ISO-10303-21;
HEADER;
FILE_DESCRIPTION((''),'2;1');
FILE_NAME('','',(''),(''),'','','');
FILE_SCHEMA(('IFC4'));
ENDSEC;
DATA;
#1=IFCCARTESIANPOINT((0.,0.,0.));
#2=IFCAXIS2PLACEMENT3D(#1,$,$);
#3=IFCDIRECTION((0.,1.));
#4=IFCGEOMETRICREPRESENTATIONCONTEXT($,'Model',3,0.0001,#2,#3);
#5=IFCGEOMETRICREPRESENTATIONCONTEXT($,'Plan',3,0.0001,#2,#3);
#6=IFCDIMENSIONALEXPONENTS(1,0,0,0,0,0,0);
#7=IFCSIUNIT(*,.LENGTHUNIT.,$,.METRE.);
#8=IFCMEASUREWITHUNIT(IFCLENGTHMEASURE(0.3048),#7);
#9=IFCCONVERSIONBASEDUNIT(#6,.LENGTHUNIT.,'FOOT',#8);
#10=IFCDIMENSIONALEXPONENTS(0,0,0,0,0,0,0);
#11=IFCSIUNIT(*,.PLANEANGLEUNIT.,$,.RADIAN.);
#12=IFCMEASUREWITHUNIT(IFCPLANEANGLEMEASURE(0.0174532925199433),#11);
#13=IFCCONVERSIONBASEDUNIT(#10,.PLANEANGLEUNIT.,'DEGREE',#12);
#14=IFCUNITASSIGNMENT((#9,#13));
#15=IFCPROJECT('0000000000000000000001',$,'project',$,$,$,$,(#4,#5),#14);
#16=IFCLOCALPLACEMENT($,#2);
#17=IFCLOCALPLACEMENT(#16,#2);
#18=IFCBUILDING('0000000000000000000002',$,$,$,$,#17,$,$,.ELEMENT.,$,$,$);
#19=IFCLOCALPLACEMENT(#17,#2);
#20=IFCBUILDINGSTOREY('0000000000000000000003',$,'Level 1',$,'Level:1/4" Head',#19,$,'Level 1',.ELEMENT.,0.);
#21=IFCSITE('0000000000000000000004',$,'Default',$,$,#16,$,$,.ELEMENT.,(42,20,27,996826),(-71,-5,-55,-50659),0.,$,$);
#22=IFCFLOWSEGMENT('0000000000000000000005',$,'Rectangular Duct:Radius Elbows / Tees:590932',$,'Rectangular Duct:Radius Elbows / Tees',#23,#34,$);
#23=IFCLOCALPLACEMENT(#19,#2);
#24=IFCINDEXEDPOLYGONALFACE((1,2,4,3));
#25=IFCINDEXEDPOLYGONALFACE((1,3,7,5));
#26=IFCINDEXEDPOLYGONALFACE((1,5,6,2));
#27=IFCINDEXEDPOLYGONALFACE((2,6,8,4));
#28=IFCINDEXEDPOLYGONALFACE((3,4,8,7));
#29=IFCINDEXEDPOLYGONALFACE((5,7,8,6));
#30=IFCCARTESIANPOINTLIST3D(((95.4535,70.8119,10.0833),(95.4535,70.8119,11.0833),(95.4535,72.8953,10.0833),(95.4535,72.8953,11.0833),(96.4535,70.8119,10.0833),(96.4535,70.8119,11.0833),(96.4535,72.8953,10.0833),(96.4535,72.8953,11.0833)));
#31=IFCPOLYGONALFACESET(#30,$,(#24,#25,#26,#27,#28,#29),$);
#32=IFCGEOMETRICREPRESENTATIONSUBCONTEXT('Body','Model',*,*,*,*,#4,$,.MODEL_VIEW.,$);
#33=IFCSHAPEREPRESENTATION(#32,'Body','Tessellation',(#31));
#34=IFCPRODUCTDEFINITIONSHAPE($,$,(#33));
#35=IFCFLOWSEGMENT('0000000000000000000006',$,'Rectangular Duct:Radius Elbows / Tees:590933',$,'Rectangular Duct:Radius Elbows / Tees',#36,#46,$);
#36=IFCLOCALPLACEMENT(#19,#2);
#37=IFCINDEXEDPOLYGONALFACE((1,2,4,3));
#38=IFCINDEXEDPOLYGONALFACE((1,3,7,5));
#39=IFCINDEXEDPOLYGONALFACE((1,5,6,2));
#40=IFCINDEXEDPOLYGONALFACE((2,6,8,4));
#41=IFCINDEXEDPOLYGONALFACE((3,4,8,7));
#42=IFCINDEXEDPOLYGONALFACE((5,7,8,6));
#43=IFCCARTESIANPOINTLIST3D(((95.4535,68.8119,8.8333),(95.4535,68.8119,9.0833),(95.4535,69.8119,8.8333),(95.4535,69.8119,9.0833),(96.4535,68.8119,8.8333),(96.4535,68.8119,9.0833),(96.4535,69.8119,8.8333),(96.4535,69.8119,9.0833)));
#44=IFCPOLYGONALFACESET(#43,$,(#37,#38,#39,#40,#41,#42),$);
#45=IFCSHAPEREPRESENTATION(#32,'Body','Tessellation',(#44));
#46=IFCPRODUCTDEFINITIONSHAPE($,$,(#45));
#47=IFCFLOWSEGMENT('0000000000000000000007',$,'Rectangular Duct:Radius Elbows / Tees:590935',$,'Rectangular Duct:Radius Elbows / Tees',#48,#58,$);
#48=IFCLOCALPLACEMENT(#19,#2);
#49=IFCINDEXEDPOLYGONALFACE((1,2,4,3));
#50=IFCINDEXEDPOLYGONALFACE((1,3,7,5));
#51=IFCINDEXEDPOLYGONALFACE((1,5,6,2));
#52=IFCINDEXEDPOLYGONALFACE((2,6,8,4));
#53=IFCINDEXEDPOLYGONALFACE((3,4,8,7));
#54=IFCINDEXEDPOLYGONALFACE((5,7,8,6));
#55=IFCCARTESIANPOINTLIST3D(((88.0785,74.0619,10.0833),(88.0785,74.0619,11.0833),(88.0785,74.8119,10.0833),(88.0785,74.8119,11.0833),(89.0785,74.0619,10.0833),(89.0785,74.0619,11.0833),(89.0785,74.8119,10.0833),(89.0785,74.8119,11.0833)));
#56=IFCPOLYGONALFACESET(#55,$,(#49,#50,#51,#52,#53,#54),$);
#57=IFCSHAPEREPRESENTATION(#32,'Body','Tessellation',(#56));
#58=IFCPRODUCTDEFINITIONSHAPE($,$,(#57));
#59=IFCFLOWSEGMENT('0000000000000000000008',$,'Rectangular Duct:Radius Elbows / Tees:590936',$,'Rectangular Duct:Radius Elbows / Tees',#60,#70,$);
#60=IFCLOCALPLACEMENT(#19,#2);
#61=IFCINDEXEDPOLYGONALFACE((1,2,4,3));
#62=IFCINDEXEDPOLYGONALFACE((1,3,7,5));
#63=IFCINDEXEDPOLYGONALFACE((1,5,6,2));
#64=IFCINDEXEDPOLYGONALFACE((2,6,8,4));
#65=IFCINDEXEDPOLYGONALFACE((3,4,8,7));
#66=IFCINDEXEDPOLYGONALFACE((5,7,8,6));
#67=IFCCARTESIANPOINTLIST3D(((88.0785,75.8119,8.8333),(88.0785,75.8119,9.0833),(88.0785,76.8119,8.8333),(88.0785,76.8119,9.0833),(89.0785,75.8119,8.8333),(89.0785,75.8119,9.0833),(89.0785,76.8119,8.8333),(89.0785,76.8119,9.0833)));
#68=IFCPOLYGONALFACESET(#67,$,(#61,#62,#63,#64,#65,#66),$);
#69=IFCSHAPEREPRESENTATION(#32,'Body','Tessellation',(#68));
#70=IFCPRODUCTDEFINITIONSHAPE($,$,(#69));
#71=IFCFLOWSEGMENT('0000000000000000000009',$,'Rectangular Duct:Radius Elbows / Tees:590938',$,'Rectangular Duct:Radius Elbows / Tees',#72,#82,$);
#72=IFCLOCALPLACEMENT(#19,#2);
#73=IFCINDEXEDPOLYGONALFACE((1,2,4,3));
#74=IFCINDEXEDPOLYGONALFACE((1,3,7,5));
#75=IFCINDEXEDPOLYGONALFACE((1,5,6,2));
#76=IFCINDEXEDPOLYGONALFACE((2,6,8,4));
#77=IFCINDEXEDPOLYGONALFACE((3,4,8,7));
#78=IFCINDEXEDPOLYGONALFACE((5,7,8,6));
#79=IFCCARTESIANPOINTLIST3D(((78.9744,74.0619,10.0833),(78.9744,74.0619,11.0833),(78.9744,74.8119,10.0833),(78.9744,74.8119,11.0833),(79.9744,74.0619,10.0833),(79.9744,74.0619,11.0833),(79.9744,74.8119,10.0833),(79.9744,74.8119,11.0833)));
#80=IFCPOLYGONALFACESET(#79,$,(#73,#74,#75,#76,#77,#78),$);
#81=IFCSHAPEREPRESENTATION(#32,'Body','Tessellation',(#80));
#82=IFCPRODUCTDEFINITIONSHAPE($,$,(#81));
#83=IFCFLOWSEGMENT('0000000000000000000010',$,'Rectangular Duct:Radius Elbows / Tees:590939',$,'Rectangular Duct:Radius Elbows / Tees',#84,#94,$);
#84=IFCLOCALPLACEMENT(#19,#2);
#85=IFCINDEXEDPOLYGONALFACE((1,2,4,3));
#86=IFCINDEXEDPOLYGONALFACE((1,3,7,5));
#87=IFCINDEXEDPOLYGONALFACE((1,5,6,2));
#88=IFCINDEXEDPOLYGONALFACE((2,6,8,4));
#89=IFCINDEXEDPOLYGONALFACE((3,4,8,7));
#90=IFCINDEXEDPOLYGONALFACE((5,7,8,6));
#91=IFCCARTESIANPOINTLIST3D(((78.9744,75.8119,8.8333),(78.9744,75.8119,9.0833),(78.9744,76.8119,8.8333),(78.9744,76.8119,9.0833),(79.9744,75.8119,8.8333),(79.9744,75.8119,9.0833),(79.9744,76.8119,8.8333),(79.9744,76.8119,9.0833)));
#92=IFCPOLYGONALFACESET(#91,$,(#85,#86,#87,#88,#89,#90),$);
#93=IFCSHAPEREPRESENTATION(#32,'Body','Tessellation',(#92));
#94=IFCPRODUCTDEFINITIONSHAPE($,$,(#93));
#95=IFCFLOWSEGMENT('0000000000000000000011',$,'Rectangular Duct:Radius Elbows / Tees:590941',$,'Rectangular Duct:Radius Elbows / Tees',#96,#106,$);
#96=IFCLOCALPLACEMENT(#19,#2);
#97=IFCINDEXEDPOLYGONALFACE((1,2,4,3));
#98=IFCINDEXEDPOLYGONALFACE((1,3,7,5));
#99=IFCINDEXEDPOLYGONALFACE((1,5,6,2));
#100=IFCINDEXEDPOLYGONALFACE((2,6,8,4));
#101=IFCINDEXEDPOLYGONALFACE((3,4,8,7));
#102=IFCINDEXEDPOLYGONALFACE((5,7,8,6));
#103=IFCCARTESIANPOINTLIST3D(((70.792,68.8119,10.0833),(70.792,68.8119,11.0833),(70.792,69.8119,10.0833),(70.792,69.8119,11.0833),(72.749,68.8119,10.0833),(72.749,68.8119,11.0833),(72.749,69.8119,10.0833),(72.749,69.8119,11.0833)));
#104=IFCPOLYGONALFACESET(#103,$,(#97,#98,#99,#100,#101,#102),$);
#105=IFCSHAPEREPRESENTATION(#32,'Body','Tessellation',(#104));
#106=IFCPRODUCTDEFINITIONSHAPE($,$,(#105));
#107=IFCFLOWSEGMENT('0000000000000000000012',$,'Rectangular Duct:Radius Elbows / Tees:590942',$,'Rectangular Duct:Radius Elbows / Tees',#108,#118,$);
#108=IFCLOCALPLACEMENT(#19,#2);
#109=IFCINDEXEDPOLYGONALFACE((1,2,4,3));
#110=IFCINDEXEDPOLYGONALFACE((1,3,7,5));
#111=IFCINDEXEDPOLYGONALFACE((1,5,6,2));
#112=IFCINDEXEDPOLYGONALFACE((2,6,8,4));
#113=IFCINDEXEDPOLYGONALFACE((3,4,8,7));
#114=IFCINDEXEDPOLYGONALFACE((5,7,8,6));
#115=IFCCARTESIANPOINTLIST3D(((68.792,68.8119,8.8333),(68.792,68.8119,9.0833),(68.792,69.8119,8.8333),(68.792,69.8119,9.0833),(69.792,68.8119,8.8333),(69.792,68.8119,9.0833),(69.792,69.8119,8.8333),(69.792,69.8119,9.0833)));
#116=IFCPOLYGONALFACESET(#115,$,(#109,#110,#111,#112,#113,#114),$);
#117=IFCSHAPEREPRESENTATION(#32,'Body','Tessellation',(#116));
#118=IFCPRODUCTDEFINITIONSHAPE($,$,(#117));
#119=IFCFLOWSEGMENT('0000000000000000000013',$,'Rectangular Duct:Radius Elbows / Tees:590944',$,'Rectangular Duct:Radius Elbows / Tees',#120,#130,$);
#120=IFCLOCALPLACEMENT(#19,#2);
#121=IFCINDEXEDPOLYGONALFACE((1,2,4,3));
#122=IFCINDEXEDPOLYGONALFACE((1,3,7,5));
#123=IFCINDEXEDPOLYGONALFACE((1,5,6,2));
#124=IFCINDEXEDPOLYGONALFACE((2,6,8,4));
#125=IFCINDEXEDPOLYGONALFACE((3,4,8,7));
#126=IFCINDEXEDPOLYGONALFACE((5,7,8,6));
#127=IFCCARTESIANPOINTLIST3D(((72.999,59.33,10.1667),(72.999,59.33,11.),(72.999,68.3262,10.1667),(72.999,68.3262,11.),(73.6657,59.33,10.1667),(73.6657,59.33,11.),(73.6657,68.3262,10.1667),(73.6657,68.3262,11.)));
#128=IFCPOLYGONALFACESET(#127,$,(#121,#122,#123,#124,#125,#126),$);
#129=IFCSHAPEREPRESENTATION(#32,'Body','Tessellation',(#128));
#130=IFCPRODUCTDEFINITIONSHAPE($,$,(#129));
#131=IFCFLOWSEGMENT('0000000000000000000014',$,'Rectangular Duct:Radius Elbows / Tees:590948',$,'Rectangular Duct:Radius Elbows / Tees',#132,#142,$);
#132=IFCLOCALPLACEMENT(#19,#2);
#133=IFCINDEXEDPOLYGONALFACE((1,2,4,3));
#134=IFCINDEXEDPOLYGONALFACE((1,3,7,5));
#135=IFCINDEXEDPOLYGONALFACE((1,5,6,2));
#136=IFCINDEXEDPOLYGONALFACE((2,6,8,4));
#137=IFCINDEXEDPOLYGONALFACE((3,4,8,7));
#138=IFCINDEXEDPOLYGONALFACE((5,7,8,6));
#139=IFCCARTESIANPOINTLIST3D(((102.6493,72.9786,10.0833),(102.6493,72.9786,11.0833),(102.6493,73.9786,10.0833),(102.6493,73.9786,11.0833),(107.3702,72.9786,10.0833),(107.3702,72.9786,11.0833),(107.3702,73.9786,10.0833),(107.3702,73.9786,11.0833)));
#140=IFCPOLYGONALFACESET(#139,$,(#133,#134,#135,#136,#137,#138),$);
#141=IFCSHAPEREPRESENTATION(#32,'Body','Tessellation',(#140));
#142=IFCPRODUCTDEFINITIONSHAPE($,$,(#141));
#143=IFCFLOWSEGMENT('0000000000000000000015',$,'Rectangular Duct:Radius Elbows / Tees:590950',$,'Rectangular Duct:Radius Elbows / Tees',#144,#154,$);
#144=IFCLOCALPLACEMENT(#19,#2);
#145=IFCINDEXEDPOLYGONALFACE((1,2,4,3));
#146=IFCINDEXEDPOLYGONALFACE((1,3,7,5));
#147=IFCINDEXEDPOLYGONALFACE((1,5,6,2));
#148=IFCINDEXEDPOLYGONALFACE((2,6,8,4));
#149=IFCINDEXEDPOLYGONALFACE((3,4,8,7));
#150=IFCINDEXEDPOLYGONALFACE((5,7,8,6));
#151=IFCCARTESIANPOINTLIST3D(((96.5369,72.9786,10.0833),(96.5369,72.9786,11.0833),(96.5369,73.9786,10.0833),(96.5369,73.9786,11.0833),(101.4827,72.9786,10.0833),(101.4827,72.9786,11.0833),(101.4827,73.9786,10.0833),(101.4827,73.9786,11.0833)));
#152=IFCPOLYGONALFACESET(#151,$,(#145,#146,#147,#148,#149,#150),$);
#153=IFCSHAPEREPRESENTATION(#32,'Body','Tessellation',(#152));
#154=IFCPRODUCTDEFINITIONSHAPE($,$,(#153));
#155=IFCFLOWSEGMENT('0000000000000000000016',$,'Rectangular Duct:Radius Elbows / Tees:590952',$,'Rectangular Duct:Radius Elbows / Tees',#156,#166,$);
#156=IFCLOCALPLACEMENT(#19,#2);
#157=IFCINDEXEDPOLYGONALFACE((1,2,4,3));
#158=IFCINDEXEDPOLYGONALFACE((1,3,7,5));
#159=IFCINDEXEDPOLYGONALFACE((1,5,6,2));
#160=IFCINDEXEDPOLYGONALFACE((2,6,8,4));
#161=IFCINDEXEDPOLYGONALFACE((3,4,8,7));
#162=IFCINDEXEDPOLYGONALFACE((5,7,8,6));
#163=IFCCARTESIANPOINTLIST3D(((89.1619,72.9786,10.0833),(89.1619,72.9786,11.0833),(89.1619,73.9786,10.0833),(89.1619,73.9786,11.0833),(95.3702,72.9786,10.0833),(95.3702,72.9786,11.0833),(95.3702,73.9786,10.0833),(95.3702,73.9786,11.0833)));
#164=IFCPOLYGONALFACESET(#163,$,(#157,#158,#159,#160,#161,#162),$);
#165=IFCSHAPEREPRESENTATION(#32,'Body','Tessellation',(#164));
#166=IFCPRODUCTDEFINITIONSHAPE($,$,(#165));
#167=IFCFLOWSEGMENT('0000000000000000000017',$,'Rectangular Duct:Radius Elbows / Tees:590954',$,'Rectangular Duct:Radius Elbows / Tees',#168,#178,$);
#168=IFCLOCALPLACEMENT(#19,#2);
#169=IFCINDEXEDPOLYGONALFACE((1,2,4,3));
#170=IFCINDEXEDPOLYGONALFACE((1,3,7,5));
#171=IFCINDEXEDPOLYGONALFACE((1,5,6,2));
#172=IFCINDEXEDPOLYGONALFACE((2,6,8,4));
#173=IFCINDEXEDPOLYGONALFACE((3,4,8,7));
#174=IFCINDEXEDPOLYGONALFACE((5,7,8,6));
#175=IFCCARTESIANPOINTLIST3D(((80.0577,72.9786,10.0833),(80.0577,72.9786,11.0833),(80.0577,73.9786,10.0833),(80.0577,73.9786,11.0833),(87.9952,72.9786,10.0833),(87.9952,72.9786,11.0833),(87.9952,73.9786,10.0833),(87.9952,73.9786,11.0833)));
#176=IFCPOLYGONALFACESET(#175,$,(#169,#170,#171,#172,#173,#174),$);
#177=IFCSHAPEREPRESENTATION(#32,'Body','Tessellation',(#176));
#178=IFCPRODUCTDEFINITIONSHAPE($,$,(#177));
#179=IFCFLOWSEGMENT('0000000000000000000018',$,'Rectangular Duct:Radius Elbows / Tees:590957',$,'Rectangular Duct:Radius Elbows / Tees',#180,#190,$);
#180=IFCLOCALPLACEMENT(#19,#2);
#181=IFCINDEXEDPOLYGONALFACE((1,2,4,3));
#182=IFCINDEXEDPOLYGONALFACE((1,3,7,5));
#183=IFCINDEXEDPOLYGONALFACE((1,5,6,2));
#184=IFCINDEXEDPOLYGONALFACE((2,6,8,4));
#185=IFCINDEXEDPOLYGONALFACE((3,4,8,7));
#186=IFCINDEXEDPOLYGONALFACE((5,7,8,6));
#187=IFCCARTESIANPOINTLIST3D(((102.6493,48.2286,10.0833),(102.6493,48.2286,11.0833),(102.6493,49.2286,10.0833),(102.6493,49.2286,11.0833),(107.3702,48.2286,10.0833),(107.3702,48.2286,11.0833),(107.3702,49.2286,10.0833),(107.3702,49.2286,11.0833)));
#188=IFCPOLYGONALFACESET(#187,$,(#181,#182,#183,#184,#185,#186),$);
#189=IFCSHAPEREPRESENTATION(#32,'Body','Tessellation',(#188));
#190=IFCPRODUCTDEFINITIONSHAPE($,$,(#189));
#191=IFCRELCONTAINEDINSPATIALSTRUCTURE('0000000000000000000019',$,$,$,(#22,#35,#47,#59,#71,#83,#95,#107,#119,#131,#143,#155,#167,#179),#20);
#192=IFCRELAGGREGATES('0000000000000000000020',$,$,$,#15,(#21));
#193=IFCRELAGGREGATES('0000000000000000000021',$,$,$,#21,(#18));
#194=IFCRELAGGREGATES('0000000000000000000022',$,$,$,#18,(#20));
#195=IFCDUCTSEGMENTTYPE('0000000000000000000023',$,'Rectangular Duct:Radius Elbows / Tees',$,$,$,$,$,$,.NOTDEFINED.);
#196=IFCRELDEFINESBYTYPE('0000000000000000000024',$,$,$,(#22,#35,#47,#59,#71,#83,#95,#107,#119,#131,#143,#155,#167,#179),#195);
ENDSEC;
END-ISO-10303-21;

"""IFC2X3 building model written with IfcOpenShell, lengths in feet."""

from ifc_helpers import new_model, entity, si_unit, converted_unit, direction, frame, frame_2d, origin, origin_2d_with_axis, place, context, subcontext, project, spatial, rectangle, extrude, type_object, element, save


model = new_model("IFC2X3")

# Units and contexts
model_context = context("Model", 3, precision=0.0001, world=origin(), true_north=direction((0.0, 1.0)))
plan_context = context("Plan", 3, precision=0.0001, world=origin(), true_north=direction((0.0, 1.0)))
body_context = subcontext(model_context, "Body", "Model", "MODEL_VIEW")
ifc_project = project(units=[converted_unit("LENGTHUNIT", "FOOT", entity("IfcLengthMeasure", 0.3048), si_unit("LENGTHUNIT", "METRE"), dimensions=[1, 0, 0, 0, 0, 0, 0]), converted_unit("PLANEANGLEUNIT", "DEGREE", entity("IfcPlaneAngleMeasure", 0.0174532925199433), si_unit("PLANEANGLEUNIT", "RADIAN"), dimensions=[0, 0, 0, 0, 0, 0, 0])], contexts=[model_context, plan_context])

# Site, building, storey
site_placement = place(None, origin())
site = spatial("IfcSite", under=ifc_project, at=site_placement, Name="Default", CompositionType="ELEMENT", RefLatitude=(42, 20, 27, 996826), RefLongitude=(-71, -5, -55, -50659), RefElevation=0.0)
building_placement = place(site_placement, origin())
building = spatial("IfcBuilding", under=site, at=building_placement, CompositionType="ELEMENT")
storey_placement = place(building_placement, origin())
storey = spatial("IfcBuildingStorey", under=building, at=storey_placement, Name="Level 1", ObjectType="Level:1/4\" Head", LongName="Level 1", CompositionType="ELEMENT", Elevation=0.0)

# Flow segments
duct_segment_type = type_object("IfcDuctSegmentType", Name="Rectangular Duct:Radius Elbows / Tees", PredefinedType="NOTDEFINED")
flow_segment_1_placement = place(storey_placement, origin())
element("IfcFlowSegment", 1, at=flow_segment_1_placement, inside=storey, type_object=duct_segment_type, Name="Rectangular Duct:Radius Elbows / Tees:590932", ObjectType="Rectangular Duct:Radius Elbows / Tees", context=body_context, shape_type="SweptSolid", body=[
    extrude(rectangle(XDim=2.0833, YDim=1.0, at=frame_2d((0.0, 0.0), x_axis=(1.0, 0.0))), frame((95.9535, 71.8536, 10.0833), z_axis=(0.0, 0.0, 1.0), x_axis=(0.0, -1.0, 0.0)), (0.0, 0.0, 1.0), 1.0),
])
flow_segment_2_placement = place(storey_placement, origin())
element("IfcFlowSegment", 2, at=flow_segment_2_placement, inside=storey, type_object=duct_segment_type, Name="Rectangular Duct:Radius Elbows / Tees:590933", ObjectType="Rectangular Duct:Radius Elbows / Tees", context=body_context, shape_type="SweptSolid", body=[
    extrude(rectangle(XDim=1.0, YDim=1.0, at=origin_2d_with_axis()), frame((95.9535, 69.3119, 8.8333), z_axis=(0.0, 0.0, 1.0), x_axis=(0.0, 1.0, 0.0)), (0.0, 0.0, 1.0), 0.25),
])
flow_segment_3_placement = place(storey_placement, origin())
element("IfcFlowSegment", 3, at=flow_segment_3_placement, inside=storey, type_object=duct_segment_type, Name="Rectangular Duct:Radius Elbows / Tees:590935", ObjectType="Rectangular Duct:Radius Elbows / Tees", context=body_context, shape_type="SweptSolid", body=[
    extrude(rectangle(XDim=0.75, YDim=1.0, at=frame_2d((0.0, 0.0), x_axis=(1.0, 0.0))), frame((88.5785, 74.4369, 10.0833), z_axis=(0.0, 0.0, 1.0), x_axis=(0.0, 1.0, 0.0)), (0.0, 0.0, 1.0), 1.0),
])
flow_segment_4_placement = place(storey_placement, origin())
element("IfcFlowSegment", 4, at=flow_segment_4_placement, inside=storey, type_object=duct_segment_type, Name="Rectangular Duct:Radius Elbows / Tees:590936", ObjectType="Rectangular Duct:Radius Elbows / Tees", context=body_context, shape_type="SweptSolid", body=[
    extrude(rectangle(XDim=1.0, YDim=1.0, at=origin_2d_with_axis()), frame((88.5785, 76.3119, 8.8333), z_axis=(0.0, 0.0, 1.0), x_axis=(0.0, 1.0, 0.0)), (0.0, 0.0, 1.0), 0.25),
])
flow_segment_5_placement = place(storey_placement, origin())
element("IfcFlowSegment", 5, at=flow_segment_5_placement, inside=storey, type_object=duct_segment_type, Name="Rectangular Duct:Radius Elbows / Tees:590938", ObjectType="Rectangular Duct:Radius Elbows / Tees", context=body_context, shape_type="SweptSolid", body=[
    extrude(rectangle(XDim=0.75, YDim=1.0, at=frame_2d((0.0, 0.0), x_axis=(1.0, 0.0))), frame((79.4744, 74.4369, 10.0833), z_axis=(0.0, 0.0, 1.0), x_axis=(0.0, 1.0, 0.0)), (0.0, 0.0, 1.0), 1.0),
])
flow_segment_6_placement = place(storey_placement, origin())
element("IfcFlowSegment", 6, at=flow_segment_6_placement, inside=storey, type_object=duct_segment_type, Name="Rectangular Duct:Radius Elbows / Tees:590939", ObjectType="Rectangular Duct:Radius Elbows / Tees", context=body_context, shape_type="SweptSolid", body=[
    extrude(rectangle(XDim=1.0, YDim=1.0, at=origin_2d_with_axis()), frame((79.4744, 76.3119, 8.8333), z_axis=(0.0, 0.0, 1.0), x_axis=(0.0, 1.0, 0.0)), (0.0, 0.0, 1.0), 0.25),
])
flow_segment_7_placement = place(storey_placement, origin())
element("IfcFlowSegment", 7, at=flow_segment_7_placement, inside=storey, type_object=duct_segment_type, Name="Rectangular Duct:Radius Elbows / Tees:590941", ObjectType="Rectangular Duct:Radius Elbows / Tees", context=body_context, shape_type="SweptSolid", body=[
    extrude(rectangle(XDim=1.957, YDim=1.0, at=origin_2d_with_axis()), frame((71.7705, 69.3119, 10.0833)), (0.0, 0.0, 1.0), 1.0),
])
flow_segment_8_placement = place(storey_placement, origin())
element("IfcFlowSegment", 8, at=flow_segment_8_placement, inside=storey, type_object=duct_segment_type, Name="Rectangular Duct:Radius Elbows / Tees:590942", ObjectType="Rectangular Duct:Radius Elbows / Tees", context=body_context, shape_type="SweptSolid", body=[
    extrude(rectangle(XDim=1.0, YDim=1.0, at=origin_2d_with_axis()), frame((69.292, 69.3119, 8.8333), z_axis=(0.0, 0.0, 1.0), x_axis=(0.0, 1.0, 0.0)), (0.0, 0.0, 1.0), 0.25),
])
flow_segment_9_placement = place(storey_placement, origin())
element("IfcFlowSegment", 9, at=flow_segment_9_placement, inside=storey, type_object=duct_segment_type, Name="Rectangular Duct:Radius Elbows / Tees:590944", ObjectType="Rectangular Duct:Radius Elbows / Tees", context=body_context, shape_type="SweptSolid", body=[
    extrude(rectangle(XDim=8.9962, YDim=0.6667, at=frame_2d((0.0, 0.0), x_axis=(1.0, 0.0))), frame((73.3323, 63.8281, 10.1667), z_axis=(0.0, 0.0, 1.0), x_axis=(0.0, 1.0, 0.0)), (0.0, 0.0, 1.0), 0.8333),
])
flow_segment_10_placement = place(storey_placement, origin())
element("IfcFlowSegment", 10, at=flow_segment_10_placement, inside=storey, type_object=duct_segment_type, Name="Rectangular Duct:Radius Elbows / Tees:590948", ObjectType="Rectangular Duct:Radius Elbows / Tees", context=body_context, shape_type="SweptSolid", body=[
    extrude(rectangle(XDim=4.7209, YDim=1.0, at=frame_2d((0.0, 0.0), x_axis=(1.0, 0.0))), frame((105.0098, 73.4786, 10.0833), z_axis=(0.0, 0.0, 1.0), x_axis=(-1.0, 0.0, 0.0)), (0.0, 0.0, 1.0), 1.0),
])
flow_segment_11_placement = place(storey_placement, origin())
element("IfcFlowSegment", 11, at=flow_segment_11_placement, inside=storey, type_object=duct_segment_type, Name="Rectangular Duct:Radius Elbows / Tees:590950", ObjectType="Rectangular Duct:Radius Elbows / Tees", context=body_context, shape_type="SweptSolid", body=[
    extrude(rectangle(XDim=4.9458, YDim=1.0, at=frame_2d((0.0, 0.0), x_axis=(1.0, 0.0))), frame((99.0098, 73.4786, 10.0833), z_axis=(0.0, 0.0, 1.0), x_axis=(-1.0, 0.0, 0.0)), (0.0, 0.0, 1.0), 1.0),
])
flow_segment_12_placement = place(storey_placement, origin())
element("IfcFlowSegment", 12, at=flow_segment_12_placement, inside=storey, type_object=duct_segment_type, Name="Rectangular Duct:Radius Elbows / Tees:590952", ObjectType="Rectangular Duct:Radius Elbows / Tees", context=body_context, shape_type="SweptSolid", body=[
    extrude(rectangle(XDim=6.2083, YDim=1.0, at=frame_2d((0.0, 0.0), x_axis=(1.0, 0.0))), frame((92.266, 73.4786, 10.0833), z_axis=(0.0, 0.0, 1.0), x_axis=(-1.0, 0.0, 0.0)), (0.0, 0.0, 1.0), 1.0),
])
flow_segment_13_placement = place(storey_placement, origin())
element("IfcFlowSegment", 13, at=flow_segment_13_placement, inside=storey, type_object=duct_segment_type, Name="Rectangular Duct:Radius Elbows / Tees:590954", ObjectType="Rectangular Duct:Radius Elbows / Tees", context=body_context, shape_type="SweptSolid", body=[
    extrude(rectangle(XDim=7.9375, YDim=1.0, at=origin_2d_with_axis()), frame((84.0265, 73.4786, 10.0833), z_axis=(0.0, 0.0, 1.0), x_axis=(-1.0, 0.0, 0.0)), (0.0, 0.0, 1.0), 1.0),
])
flow_segment_14_placement = place(storey_placement, origin())
element("IfcFlowSegment", 14, at=flow_segment_14_placement, inside=storey, type_object=duct_segment_type, Name="Rectangular Duct:Radius Elbows / Tees:590957", ObjectType="Rectangular Duct:Radius Elbows / Tees", context=body_context, shape_type="SweptSolid", body=[
    extrude(rectangle(XDim=4.7209, YDim=1.0, at=origin_2d_with_axis()), frame((105.0098, 48.7286, 10.0833)), (0.0, 0.0, 1.0), 1.0),
])

save(model, "model.ifc")
